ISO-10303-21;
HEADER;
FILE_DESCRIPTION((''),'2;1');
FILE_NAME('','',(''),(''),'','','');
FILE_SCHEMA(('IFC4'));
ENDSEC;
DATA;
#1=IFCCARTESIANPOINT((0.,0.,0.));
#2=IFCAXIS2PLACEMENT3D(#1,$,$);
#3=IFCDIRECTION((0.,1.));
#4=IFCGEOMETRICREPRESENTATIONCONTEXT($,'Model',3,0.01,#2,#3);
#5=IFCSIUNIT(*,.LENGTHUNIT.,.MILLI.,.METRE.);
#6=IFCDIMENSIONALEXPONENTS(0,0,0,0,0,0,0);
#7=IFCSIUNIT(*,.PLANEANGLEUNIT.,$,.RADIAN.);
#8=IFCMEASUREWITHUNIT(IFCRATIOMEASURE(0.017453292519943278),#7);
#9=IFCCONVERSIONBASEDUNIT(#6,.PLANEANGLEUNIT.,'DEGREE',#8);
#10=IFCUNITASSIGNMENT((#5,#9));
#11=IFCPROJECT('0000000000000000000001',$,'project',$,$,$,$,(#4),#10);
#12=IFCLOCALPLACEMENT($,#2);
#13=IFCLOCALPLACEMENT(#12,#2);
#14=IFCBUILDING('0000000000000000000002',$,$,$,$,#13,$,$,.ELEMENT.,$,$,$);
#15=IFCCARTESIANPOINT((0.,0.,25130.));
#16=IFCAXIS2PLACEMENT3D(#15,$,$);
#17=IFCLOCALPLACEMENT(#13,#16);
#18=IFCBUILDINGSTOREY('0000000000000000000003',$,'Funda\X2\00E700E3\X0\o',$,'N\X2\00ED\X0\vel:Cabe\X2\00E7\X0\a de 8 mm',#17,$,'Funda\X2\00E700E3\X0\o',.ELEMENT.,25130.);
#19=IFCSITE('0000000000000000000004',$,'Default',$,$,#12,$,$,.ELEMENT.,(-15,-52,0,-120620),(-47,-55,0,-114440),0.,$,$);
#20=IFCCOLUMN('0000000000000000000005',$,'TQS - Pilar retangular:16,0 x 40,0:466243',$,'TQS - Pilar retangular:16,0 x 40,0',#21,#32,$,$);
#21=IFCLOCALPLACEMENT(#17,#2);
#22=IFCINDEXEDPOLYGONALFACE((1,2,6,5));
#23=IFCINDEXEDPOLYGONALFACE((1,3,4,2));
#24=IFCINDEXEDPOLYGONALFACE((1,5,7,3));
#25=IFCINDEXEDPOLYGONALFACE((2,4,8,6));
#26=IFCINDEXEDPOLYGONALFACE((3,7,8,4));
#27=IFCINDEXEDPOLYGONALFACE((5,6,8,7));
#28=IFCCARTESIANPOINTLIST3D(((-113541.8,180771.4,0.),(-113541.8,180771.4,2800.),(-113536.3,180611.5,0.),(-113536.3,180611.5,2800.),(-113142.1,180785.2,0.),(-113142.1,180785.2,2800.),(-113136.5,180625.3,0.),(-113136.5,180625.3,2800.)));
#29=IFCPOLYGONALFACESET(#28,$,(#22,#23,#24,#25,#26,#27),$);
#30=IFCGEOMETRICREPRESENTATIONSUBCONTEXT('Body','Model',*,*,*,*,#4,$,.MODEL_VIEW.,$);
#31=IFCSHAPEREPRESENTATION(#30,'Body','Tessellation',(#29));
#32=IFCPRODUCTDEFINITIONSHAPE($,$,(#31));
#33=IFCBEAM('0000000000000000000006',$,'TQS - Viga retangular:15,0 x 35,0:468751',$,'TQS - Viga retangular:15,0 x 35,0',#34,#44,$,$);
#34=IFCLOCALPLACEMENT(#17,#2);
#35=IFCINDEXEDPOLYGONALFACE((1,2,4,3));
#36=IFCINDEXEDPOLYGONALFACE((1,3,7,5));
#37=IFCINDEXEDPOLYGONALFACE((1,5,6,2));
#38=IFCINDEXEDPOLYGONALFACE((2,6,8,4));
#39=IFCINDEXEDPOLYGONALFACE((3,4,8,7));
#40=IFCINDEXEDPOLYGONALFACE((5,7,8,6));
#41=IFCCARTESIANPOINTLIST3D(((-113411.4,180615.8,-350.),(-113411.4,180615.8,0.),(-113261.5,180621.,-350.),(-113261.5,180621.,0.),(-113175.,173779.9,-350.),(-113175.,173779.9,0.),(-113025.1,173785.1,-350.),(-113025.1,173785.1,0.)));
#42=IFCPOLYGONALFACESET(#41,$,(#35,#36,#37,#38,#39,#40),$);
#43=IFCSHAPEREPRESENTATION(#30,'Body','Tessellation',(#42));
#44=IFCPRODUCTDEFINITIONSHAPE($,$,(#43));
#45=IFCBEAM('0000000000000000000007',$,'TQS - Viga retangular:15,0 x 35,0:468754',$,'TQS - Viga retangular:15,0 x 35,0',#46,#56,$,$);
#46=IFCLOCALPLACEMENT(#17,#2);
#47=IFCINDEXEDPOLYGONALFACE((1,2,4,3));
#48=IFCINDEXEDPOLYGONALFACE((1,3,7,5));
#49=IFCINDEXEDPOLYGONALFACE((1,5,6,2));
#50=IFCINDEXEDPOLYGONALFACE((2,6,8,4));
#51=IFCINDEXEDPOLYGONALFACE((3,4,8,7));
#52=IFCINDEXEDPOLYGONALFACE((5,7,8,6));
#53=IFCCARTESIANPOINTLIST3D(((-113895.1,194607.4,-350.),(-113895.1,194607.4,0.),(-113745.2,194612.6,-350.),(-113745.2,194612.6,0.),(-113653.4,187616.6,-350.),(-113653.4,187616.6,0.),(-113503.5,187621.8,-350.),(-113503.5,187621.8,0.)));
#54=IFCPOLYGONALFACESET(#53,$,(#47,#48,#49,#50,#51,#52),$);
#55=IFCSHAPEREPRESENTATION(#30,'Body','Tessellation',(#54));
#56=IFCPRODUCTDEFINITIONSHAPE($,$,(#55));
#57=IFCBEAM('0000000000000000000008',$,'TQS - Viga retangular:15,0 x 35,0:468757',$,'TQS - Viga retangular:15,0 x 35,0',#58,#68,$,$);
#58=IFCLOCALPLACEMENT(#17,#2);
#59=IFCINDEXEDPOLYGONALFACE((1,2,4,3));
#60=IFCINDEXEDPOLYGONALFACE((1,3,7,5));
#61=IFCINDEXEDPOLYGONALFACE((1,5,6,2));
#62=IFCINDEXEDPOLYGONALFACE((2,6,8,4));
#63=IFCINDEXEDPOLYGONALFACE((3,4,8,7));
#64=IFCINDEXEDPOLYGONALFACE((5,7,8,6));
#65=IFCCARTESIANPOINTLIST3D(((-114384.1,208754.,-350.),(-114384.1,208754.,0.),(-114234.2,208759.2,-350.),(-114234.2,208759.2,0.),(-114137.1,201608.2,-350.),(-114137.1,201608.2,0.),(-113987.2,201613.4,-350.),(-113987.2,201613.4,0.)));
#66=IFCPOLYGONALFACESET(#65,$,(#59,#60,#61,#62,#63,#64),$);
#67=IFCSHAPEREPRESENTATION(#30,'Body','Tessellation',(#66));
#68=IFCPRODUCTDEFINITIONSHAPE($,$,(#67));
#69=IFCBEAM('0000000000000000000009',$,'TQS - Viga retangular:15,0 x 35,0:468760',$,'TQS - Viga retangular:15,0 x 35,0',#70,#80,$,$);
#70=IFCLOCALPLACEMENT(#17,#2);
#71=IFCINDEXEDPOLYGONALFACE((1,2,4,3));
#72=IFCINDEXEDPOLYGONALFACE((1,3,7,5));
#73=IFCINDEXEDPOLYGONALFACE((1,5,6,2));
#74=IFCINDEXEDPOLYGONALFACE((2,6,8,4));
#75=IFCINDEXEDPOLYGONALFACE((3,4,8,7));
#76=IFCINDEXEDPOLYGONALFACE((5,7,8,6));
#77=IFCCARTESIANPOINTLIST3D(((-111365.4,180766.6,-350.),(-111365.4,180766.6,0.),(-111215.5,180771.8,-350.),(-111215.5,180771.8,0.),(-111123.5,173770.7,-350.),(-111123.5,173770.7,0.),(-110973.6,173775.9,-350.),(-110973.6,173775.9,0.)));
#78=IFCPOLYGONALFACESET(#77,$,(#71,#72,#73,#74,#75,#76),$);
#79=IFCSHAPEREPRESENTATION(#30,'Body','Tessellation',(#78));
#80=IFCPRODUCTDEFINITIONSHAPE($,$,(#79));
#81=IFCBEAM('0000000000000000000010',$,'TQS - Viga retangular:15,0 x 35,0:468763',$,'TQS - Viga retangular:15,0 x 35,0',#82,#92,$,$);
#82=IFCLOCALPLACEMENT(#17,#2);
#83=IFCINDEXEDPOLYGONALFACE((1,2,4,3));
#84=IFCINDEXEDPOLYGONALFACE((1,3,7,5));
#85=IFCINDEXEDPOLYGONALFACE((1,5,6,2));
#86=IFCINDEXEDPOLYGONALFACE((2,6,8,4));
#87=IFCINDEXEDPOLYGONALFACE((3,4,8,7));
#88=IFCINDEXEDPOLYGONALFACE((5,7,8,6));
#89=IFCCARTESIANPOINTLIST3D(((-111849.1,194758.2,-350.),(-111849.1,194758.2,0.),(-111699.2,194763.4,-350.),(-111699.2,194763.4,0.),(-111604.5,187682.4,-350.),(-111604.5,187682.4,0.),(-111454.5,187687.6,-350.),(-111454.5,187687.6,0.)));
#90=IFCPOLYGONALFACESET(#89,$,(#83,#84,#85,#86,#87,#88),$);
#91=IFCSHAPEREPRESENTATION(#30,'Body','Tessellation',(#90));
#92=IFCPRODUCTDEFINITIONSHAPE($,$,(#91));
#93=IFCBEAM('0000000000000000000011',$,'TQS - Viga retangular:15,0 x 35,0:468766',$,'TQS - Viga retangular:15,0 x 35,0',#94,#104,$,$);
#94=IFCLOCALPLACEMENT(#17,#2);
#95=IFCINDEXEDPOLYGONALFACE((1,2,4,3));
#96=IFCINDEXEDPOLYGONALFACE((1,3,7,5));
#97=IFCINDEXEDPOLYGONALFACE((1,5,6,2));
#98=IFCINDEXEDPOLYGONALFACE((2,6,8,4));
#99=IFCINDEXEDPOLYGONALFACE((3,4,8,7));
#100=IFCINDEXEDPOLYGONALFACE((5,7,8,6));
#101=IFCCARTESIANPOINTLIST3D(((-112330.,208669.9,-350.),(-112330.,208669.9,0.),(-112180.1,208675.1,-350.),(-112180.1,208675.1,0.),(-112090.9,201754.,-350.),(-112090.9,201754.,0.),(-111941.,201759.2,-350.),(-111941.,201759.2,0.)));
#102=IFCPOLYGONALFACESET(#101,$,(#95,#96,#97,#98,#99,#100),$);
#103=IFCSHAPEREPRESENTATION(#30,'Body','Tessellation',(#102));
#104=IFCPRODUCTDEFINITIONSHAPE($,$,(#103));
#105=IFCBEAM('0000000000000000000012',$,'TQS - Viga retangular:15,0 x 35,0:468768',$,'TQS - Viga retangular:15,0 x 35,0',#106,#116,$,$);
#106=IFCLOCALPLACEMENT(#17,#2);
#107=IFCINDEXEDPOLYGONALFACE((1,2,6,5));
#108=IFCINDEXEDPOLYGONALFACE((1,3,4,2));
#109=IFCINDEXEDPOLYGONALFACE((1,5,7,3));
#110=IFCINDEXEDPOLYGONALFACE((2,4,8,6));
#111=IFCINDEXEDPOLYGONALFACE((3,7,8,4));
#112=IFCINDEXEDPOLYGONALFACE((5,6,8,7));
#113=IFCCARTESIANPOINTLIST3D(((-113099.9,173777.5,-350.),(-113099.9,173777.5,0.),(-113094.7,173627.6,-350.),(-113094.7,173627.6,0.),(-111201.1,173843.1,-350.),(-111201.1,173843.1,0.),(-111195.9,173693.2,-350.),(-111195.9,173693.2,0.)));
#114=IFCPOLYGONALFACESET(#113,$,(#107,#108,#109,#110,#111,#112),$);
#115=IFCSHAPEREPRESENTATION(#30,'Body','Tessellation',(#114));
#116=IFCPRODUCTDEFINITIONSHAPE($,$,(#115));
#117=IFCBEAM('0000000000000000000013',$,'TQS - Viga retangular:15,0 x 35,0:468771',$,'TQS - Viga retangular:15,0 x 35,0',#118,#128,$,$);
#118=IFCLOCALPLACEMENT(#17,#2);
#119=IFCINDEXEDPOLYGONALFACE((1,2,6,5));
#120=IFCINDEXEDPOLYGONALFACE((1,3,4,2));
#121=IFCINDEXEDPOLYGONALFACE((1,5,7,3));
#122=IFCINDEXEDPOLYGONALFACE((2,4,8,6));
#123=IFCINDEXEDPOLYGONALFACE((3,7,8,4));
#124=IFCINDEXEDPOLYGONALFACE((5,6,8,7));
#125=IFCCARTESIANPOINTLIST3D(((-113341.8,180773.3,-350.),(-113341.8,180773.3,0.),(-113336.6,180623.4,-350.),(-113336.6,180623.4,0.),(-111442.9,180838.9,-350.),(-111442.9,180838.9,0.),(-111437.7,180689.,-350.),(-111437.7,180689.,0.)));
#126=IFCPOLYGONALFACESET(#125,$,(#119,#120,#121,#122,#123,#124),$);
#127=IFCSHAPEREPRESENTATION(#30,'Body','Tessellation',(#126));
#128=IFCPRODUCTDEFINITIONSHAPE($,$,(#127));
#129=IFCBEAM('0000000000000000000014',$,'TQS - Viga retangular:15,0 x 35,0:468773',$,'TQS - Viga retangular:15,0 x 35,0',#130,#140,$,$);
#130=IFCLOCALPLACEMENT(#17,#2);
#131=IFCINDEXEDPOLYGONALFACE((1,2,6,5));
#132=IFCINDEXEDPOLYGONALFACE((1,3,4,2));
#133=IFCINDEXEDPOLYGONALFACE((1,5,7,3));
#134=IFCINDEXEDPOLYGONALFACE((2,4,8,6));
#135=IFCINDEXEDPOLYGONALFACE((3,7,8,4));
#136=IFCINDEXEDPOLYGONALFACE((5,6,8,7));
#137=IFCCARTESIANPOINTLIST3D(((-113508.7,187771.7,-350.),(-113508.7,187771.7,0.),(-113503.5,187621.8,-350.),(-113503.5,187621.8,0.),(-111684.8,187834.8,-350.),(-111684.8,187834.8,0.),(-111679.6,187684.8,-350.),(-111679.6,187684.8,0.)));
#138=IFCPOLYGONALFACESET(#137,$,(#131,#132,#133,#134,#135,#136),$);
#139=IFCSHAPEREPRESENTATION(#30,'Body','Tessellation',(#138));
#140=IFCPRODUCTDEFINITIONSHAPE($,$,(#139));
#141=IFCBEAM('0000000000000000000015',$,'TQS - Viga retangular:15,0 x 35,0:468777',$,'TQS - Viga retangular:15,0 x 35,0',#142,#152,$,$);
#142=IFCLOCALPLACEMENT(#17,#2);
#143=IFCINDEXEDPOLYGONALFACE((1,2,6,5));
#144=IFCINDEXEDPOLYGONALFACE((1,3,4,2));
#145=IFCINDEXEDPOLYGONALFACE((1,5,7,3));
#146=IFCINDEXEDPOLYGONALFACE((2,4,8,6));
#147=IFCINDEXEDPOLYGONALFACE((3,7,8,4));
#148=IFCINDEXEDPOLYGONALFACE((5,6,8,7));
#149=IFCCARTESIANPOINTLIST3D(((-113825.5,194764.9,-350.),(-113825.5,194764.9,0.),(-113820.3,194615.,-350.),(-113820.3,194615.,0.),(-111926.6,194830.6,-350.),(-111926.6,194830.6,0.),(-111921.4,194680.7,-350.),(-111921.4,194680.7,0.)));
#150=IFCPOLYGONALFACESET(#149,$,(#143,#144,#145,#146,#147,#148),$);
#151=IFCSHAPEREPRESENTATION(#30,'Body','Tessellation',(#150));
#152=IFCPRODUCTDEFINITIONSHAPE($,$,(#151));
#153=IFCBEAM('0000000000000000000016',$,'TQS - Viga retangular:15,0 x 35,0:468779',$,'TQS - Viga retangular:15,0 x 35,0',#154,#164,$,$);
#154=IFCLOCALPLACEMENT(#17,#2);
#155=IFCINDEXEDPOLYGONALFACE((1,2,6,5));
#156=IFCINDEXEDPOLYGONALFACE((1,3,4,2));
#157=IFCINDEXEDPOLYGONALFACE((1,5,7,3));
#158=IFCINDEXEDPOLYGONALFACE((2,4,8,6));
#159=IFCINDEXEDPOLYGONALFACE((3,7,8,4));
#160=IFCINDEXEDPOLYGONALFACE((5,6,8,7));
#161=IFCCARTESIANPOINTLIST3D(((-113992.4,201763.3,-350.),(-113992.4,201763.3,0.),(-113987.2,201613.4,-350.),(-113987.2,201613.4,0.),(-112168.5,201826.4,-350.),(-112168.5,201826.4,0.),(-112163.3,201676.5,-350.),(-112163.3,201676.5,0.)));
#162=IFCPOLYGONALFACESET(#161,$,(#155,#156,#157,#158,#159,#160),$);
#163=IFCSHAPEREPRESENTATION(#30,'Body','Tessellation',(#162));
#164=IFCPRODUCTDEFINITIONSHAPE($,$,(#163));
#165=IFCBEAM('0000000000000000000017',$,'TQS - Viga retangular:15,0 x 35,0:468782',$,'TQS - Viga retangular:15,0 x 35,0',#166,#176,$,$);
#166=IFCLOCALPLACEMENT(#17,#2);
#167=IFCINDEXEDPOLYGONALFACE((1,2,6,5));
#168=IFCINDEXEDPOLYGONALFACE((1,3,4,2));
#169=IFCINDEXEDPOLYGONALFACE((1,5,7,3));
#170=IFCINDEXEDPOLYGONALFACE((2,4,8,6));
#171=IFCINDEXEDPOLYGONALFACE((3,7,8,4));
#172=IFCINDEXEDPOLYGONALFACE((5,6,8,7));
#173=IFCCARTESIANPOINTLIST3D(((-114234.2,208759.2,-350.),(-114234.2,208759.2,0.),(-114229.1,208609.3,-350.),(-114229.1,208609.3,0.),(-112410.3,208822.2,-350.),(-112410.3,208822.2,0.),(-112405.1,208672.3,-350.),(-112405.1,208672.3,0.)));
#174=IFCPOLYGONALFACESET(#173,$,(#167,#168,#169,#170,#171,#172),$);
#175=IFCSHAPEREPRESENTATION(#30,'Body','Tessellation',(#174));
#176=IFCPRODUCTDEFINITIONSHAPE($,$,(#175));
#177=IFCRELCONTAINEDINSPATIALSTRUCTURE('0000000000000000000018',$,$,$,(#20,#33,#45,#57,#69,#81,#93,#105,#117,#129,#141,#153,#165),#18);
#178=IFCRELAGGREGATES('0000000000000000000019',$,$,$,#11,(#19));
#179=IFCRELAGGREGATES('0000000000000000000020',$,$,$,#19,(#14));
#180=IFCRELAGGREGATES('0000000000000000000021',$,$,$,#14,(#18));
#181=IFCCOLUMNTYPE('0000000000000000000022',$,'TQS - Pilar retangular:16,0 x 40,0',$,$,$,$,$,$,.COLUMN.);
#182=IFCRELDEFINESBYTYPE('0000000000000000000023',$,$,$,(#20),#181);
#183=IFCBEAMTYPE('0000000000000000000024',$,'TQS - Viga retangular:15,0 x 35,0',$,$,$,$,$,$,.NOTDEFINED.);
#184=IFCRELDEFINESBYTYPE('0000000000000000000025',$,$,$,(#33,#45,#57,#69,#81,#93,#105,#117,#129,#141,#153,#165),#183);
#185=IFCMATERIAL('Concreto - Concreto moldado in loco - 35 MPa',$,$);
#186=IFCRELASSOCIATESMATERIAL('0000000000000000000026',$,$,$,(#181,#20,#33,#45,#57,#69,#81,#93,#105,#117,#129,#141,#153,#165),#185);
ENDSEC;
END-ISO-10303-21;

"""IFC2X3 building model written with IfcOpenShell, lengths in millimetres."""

from ifc_helpers import new_model, entity, si_unit, converted_unit, direction, frame, frame_2d, origin, origin_2d_with_axis, place, context, subcontext, project, spatial, rectangle, extrude, source, transform, mapped, material, type_object, type_shapes, element, save


model = new_model("IFC2X3")

# Units and contexts
model_context = context("Model", 3, precision=0.01, world=origin(), true_north=direction((0.0, 1.0)))
body_context = subcontext(model_context, "Body", "Model", "MODEL_VIEW")
ifc_project = project(units=[si_unit("LENGTHUNIT", "METRE", prefix="MILLI"), converted_unit("PLANEANGLEUNIT", "DEGREE", entity("IfcRatioMeasure", 0.017453292519943278), si_unit("PLANEANGLEUNIT", "RADIAN"), dimensions=[0, 0, 0, 0, 0, 0, 0])], contexts=[model_context])

# Site, building, storey
site_placement = place(None, origin())
site = spatial("IfcSite", under=ifc_project, at=site_placement, Name="Default", CompositionType="ELEMENT", RefLatitude=(-15, -52, 0, -120620), RefLongitude=(-47, -55, 0, -114440), RefElevation=0.0)
building_placement = place(site_placement, origin())
building = spatial("IfcBuilding", under=site, at=building_placement, CompositionType="ELEMENT")
storey_placement = place(building_placement, frame((0.0, 0.0, 25130.0)))
storey = spatial("IfcBuildingStorey", under=building, at=storey_placement, Name="Fundação", ObjectType="Nível:Cabeça de 8 mm", LongName="Fundação", CompositionType="ELEMENT", Elevation=25130.0)

# Column
ifc_material_1 = material(Name="Concreto - Concreto moldado in loco - 35 MPa")
column_type_1 = type_object("IfcColumnType", Name="TQS - Pilar retangular:16,0 x 40,0", PredefinedType="COLUMN", material=ifc_material_1)
shared_shape_1 = source(origin(), body_context, "Body", "SweptSolid", [
    extrude(rectangle(XDim=400.0, YDim=160.0, at=origin_2d_with_axis()), frame((-113339.2, 180698.3, 25130.0), z_axis=(0.0, 0.0, 1.0), x_axis=(-0.999403, -0.034551, 0.0)), (0.0, 0.0, 1.0), 2800.0),
])
type_shapes(column_type_1, [shared_shape_1])
column_1_placement = place(storey_placement, frame((0.0, 0.0, -25130.0)))
element("IfcColumn", 1, at=column_1_placement, inside=storey, type_object=column_type_1, material=ifc_material_1, Name="TQS - Pilar retangular:16,0 x 40,0:466243", ObjectType="TQS - Pilar retangular:16,0 x 40,0", context=body_context, shape_type="MappedRepresentation", body=[
    mapped(shared_shape_1, transform((0.0, 0.0, 0.0), scale=1.0)),
])

# Beams
beam_type = type_object("IfcBeamType", Name="TQS - Viga retangular:15,0 x 35,0", PredefinedType="NOTDEFINED")
beam_1_placement = place(storey_placement, frame((-113100.1, 173782.5, 0.0), z_axis=(0.0, 0.0, 1.0), x_axis=(-0.034551, 0.999403, 0.0)))
element("IfcBeam", 2, at=beam_1_placement, inside=storey, type_object=beam_type, material=ifc_material_1, Name="TQS - Viga retangular:15,0 x 35,0:468751", ObjectType="TQS - Viga retangular:15,0 x 35,0", context=body_context, shape_type="SweptSolid", body=[
    extrude(rectangle(XDim=350.0, YDim=150.0, at=origin_2d_with_axis()), frame((0.0, 0.0, -175.0), z_axis=(1.0, 0.0, 0.0), x_axis=(0.0, 0.0, -1.0)), (0.0, 0.0, 1.0), 6840.0),
])
beam_2_placement = place(storey_placement, frame((-113581.0, 187694.2, 0.0), z_axis=(0.0, 0.0, 1.0), x_axis=(-0.034551, 0.999403, 0.0)))
element("IfcBeam", 3, at=beam_2_placement, inside=storey, type_object=beam_type, material=ifc_material_1, Name="TQS - Viga retangular:15,0 x 35,0:468754", ObjectType="TQS - Viga retangular:15,0 x 35,0", context=body_context, shape_type="SweptSolid", body=[
    extrude(rectangle(XDim=350.0, YDim=150.0, at=frame_2d((0.0, 0.0), x_axis=(1.0, 0.0))), frame((-75.0, 0.0, -175.0), z_axis=(1.0, 0.0, 0.0), x_axis=(0.0, 0.0, -1.0)), (0.0, 0.0, 1.0), 6995.0),
])
beam_3_placement = place(storey_placement, frame((-114064.7, 201685.8, 0.0), z_axis=(0.0, 0.0, 1.0), x_axis=(-0.034551, 0.999403, 0.0)))
element("IfcBeam", 4, at=beam_3_placement, inside=storey, type_object=beam_type, material=ifc_material_1, Name="TQS - Viga retangular:15,0 x 35,0:468757", ObjectType="TQS - Viga retangular:15,0 x 35,0", context=body_context, shape_type="SweptSolid", body=[
    extrude(rectangle(XDim=350.0, YDim=150.0, at=frame_2d((0.0, 0.0), x_axis=(1.0, 0.0))), frame((-75.0, 0.0, -175.0), z_axis=(1.0, 0.0, 0.0), x_axis=(0.0, 0.0, -1.0)), (0.0, 0.0, 1.0), 7150.0),
])
beam_4_placement = place(storey_placement, frame((-111048.6, 173773.3, 0.0), z_axis=(0.0, 0.0, 1.0), x_axis=(-0.034551, 0.999403, 0.0)))
element("IfcBeam", 5, at=beam_4_placement, inside=storey, type_object=beam_type, material=ifc_material_1, Name="TQS - Viga retangular:15,0 x 35,0:468760", ObjectType="TQS - Viga retangular:15,0 x 35,0", context=body_context, shape_type="SweptSolid", body=[
    extrude(rectangle(XDim=350.0, YDim=150.0, at=origin_2d_with_axis()), frame((0.0, 0.0, -175.0), z_axis=(1.0, 0.0, 0.0), x_axis=(0.0, 0.0, -1.0)), (0.0, 0.0, 1.0), 7000.0),
])
beam_5_placement = place(storey_placement, frame((-111529.5, 187685.0, 0.0), z_axis=(0.0, 0.0, 1.0), x_axis=(-0.034551, 0.999403, 0.0)))
element("IfcBeam", 6, at=beam_5_placement, inside=storey, type_object=beam_type, material=ifc_material_1, Name="TQS - Viga retangular:15,0 x 35,0:468763", ObjectType="TQS - Viga retangular:15,0 x 35,0", context=body_context, shape_type="SweptSolid", body=[
    extrude(rectangle(XDim=350.0, YDim=150.0, at=origin_2d_with_axis()), frame((0.0, 0.0, -175.0), z_axis=(1.0, 0.0, 0.0), x_axis=(0.0, 0.0, -1.0)), (0.0, 0.0, 1.0), 7080.0),
])
beam_6_placement = place(storey_placement, frame((-112016.0, 201756.6, 0.0), z_axis=(0.0, 0.0, 1.0), x_axis=(-0.034551, 0.999403, 0.0)))
element("IfcBeam", 7, at=beam_6_placement, inside=storey, type_object=beam_type, material=ifc_material_1, Name="TQS - Viga retangular:15,0 x 35,0:468766", ObjectType="TQS - Viga retangular:15,0 x 35,0", context=body_context, shape_type="SweptSolid", body=[
    extrude(rectangle(XDim=350.0, YDim=150.0, at=origin_2d_with_axis()), frame((0.0, 0.0, -175.0), z_axis=(1.0, 0.0, 0.0), x_axis=(0.0, 0.0, -1.0)), (0.0, 0.0, 1.0), 6920.0),
])
beam_7_placement = place(storey_placement, frame((-111198.5, 173768.2, 0.0), z_axis=(0.0, 0.0, 1.0), x_axis=(-0.999403, -0.034551, 0.0)))
element("IfcBeam", 8, at=beam_7_placement, inside=storey, type_object=beam_type, material=ifc_material_1, Name="TQS - Viga retangular:15,0 x 35,0:468768", ObjectType="TQS - Viga retangular:15,0 x 35,0", context=body_context, shape_type="SweptSolid", body=[
    extrude(rectangle(XDim=350.0, YDim=150.0, at=origin_2d_with_axis()), frame((0.0, 0.0, -175.0), z_axis=(1.0, 0.0, 0.0), x_axis=(0.0, 0.0, -1.0)), (0.0, 0.0, 1.0), 1900.0),
])
beam_8_placement = place(storey_placement, frame((-111440.3, 180764.0, 0.0), z_axis=(0.0, 0.0, 1.0), x_axis=(-0.999403, -0.034551, 0.0)))
element("IfcBeam", 9, at=beam_8_placement, inside=storey, type_object=beam_type, material=ifc_material_1, Name="TQS - Viga retangular:15,0 x 35,0:468771", ObjectType="TQS - Viga retangular:15,0 x 35,0", context=body_context, shape_type="SweptSolid", body=[
    extrude(rectangle(XDim=350.0, YDim=150.0, at=origin_2d_with_axis()), frame((0.0, 0.0, -175.0), z_axis=(1.0, 0.0, 0.0), x_axis=(0.0, 0.0, -1.0)), (0.0, 0.0, 1.0), 1900.0),
])
beam_9_placement = place(storey_placement, frame((-111682.2, 187759.8, 0.0), z_axis=(0.0, 0.0, 1.0), x_axis=(-0.999403, -0.034551, 0.0)))
element("IfcBeam", 10, at=beam_9_placement, inside=storey, type_object=beam_type, material=ifc_material_1, Name="TQS - Viga retangular:15,0 x 35,0:468773", ObjectType="TQS - Viga retangular:15,0 x 35,0", context=body_context, shape_type="SweptSolid", body=[
    extrude(rectangle(XDim=350.0, YDim=150.0, at=frame_2d((0.0, 0.0), x_axis=(1.0, 0.0))), frame((0.0, 0.0, -175.0), z_axis=(1.0, 0.0, 0.0), x_axis=(0.0, 0.0, -1.0)), (0.0, 0.0, 1.0), 1825.0),
])
beam_10_placement = place(storey_placement, frame((-111924.0, 194755.6, 0.0), z_axis=(0.0, 0.0, 1.0), x_axis=(-0.999403, -0.034551, 0.0)))
element("IfcBeam", 11, at=beam_10_placement, inside=storey, type_object=beam_type, material=ifc_material_1, Name="TQS - Viga retangular:15,0 x 35,0:468777", ObjectType="TQS - Viga retangular:15,0 x 35,0", context=body_context, shape_type="SweptSolid", body=[
    extrude(rectangle(XDim=350.0, YDim=150.0, at=frame_2d((0.0, 0.0), x_axis=(1.0, 0.0))), frame((0.0, 0.0, -175.0), z_axis=(1.0, 0.0, 0.0), x_axis=(0.0, 0.0, -1.0)), (0.0, 0.0, 1.0), 1900.0),
])
beam_11_placement = place(storey_placement, frame((-112165.9, 201751.4, 0.0), z_axis=(0.0, 0.0, 1.0), x_axis=(-0.999403, -0.034551, 0.0)))
element("IfcBeam", 12, at=beam_11_placement, inside=storey, type_object=beam_type, material=ifc_material_1, Name="TQS - Viga retangular:15,0 x 35,0:468779", ObjectType="TQS - Viga retangular:15,0 x 35,0", context=body_context, shape_type="SweptSolid", body=[
    extrude(rectangle(XDim=350.0, YDim=150.0, at=frame_2d((0.0, 0.0), x_axis=(1.0, 0.0))), frame((0.0, 0.0, -175.0), z_axis=(1.0, 0.0, 0.0), x_axis=(0.0, 0.0, -1.0)), (0.0, 0.0, 1.0), 1825.0),
])
beam_12_placement = place(storey_placement, frame((-112407.7, 208747.3, 0.0), z_axis=(0.0, 0.0, 1.0), x_axis=(-0.999403, -0.034551, 0.0)))
element("IfcBeam", 13, at=beam_12_placement, inside=storey, type_object=beam_type, material=ifc_material_1, Name="TQS - Viga retangular:15,0 x 35,0:468782", ObjectType="TQS - Viga retangular:15,0 x 35,0", context=body_context, shape_type="SweptSolid", body=[
    extrude(rectangle(XDim=350.0, YDim=150.0, at=frame_2d((0.0, 0.0), x_axis=(1.0, 0.0))), frame((0.0, 0.0, -175.0), z_axis=(1.0, 0.0, 0.0), x_axis=(0.0, 0.0, -1.0)), (0.0, 0.0, 1.0), 1825.0),
])

save(model, "model.ifc")
